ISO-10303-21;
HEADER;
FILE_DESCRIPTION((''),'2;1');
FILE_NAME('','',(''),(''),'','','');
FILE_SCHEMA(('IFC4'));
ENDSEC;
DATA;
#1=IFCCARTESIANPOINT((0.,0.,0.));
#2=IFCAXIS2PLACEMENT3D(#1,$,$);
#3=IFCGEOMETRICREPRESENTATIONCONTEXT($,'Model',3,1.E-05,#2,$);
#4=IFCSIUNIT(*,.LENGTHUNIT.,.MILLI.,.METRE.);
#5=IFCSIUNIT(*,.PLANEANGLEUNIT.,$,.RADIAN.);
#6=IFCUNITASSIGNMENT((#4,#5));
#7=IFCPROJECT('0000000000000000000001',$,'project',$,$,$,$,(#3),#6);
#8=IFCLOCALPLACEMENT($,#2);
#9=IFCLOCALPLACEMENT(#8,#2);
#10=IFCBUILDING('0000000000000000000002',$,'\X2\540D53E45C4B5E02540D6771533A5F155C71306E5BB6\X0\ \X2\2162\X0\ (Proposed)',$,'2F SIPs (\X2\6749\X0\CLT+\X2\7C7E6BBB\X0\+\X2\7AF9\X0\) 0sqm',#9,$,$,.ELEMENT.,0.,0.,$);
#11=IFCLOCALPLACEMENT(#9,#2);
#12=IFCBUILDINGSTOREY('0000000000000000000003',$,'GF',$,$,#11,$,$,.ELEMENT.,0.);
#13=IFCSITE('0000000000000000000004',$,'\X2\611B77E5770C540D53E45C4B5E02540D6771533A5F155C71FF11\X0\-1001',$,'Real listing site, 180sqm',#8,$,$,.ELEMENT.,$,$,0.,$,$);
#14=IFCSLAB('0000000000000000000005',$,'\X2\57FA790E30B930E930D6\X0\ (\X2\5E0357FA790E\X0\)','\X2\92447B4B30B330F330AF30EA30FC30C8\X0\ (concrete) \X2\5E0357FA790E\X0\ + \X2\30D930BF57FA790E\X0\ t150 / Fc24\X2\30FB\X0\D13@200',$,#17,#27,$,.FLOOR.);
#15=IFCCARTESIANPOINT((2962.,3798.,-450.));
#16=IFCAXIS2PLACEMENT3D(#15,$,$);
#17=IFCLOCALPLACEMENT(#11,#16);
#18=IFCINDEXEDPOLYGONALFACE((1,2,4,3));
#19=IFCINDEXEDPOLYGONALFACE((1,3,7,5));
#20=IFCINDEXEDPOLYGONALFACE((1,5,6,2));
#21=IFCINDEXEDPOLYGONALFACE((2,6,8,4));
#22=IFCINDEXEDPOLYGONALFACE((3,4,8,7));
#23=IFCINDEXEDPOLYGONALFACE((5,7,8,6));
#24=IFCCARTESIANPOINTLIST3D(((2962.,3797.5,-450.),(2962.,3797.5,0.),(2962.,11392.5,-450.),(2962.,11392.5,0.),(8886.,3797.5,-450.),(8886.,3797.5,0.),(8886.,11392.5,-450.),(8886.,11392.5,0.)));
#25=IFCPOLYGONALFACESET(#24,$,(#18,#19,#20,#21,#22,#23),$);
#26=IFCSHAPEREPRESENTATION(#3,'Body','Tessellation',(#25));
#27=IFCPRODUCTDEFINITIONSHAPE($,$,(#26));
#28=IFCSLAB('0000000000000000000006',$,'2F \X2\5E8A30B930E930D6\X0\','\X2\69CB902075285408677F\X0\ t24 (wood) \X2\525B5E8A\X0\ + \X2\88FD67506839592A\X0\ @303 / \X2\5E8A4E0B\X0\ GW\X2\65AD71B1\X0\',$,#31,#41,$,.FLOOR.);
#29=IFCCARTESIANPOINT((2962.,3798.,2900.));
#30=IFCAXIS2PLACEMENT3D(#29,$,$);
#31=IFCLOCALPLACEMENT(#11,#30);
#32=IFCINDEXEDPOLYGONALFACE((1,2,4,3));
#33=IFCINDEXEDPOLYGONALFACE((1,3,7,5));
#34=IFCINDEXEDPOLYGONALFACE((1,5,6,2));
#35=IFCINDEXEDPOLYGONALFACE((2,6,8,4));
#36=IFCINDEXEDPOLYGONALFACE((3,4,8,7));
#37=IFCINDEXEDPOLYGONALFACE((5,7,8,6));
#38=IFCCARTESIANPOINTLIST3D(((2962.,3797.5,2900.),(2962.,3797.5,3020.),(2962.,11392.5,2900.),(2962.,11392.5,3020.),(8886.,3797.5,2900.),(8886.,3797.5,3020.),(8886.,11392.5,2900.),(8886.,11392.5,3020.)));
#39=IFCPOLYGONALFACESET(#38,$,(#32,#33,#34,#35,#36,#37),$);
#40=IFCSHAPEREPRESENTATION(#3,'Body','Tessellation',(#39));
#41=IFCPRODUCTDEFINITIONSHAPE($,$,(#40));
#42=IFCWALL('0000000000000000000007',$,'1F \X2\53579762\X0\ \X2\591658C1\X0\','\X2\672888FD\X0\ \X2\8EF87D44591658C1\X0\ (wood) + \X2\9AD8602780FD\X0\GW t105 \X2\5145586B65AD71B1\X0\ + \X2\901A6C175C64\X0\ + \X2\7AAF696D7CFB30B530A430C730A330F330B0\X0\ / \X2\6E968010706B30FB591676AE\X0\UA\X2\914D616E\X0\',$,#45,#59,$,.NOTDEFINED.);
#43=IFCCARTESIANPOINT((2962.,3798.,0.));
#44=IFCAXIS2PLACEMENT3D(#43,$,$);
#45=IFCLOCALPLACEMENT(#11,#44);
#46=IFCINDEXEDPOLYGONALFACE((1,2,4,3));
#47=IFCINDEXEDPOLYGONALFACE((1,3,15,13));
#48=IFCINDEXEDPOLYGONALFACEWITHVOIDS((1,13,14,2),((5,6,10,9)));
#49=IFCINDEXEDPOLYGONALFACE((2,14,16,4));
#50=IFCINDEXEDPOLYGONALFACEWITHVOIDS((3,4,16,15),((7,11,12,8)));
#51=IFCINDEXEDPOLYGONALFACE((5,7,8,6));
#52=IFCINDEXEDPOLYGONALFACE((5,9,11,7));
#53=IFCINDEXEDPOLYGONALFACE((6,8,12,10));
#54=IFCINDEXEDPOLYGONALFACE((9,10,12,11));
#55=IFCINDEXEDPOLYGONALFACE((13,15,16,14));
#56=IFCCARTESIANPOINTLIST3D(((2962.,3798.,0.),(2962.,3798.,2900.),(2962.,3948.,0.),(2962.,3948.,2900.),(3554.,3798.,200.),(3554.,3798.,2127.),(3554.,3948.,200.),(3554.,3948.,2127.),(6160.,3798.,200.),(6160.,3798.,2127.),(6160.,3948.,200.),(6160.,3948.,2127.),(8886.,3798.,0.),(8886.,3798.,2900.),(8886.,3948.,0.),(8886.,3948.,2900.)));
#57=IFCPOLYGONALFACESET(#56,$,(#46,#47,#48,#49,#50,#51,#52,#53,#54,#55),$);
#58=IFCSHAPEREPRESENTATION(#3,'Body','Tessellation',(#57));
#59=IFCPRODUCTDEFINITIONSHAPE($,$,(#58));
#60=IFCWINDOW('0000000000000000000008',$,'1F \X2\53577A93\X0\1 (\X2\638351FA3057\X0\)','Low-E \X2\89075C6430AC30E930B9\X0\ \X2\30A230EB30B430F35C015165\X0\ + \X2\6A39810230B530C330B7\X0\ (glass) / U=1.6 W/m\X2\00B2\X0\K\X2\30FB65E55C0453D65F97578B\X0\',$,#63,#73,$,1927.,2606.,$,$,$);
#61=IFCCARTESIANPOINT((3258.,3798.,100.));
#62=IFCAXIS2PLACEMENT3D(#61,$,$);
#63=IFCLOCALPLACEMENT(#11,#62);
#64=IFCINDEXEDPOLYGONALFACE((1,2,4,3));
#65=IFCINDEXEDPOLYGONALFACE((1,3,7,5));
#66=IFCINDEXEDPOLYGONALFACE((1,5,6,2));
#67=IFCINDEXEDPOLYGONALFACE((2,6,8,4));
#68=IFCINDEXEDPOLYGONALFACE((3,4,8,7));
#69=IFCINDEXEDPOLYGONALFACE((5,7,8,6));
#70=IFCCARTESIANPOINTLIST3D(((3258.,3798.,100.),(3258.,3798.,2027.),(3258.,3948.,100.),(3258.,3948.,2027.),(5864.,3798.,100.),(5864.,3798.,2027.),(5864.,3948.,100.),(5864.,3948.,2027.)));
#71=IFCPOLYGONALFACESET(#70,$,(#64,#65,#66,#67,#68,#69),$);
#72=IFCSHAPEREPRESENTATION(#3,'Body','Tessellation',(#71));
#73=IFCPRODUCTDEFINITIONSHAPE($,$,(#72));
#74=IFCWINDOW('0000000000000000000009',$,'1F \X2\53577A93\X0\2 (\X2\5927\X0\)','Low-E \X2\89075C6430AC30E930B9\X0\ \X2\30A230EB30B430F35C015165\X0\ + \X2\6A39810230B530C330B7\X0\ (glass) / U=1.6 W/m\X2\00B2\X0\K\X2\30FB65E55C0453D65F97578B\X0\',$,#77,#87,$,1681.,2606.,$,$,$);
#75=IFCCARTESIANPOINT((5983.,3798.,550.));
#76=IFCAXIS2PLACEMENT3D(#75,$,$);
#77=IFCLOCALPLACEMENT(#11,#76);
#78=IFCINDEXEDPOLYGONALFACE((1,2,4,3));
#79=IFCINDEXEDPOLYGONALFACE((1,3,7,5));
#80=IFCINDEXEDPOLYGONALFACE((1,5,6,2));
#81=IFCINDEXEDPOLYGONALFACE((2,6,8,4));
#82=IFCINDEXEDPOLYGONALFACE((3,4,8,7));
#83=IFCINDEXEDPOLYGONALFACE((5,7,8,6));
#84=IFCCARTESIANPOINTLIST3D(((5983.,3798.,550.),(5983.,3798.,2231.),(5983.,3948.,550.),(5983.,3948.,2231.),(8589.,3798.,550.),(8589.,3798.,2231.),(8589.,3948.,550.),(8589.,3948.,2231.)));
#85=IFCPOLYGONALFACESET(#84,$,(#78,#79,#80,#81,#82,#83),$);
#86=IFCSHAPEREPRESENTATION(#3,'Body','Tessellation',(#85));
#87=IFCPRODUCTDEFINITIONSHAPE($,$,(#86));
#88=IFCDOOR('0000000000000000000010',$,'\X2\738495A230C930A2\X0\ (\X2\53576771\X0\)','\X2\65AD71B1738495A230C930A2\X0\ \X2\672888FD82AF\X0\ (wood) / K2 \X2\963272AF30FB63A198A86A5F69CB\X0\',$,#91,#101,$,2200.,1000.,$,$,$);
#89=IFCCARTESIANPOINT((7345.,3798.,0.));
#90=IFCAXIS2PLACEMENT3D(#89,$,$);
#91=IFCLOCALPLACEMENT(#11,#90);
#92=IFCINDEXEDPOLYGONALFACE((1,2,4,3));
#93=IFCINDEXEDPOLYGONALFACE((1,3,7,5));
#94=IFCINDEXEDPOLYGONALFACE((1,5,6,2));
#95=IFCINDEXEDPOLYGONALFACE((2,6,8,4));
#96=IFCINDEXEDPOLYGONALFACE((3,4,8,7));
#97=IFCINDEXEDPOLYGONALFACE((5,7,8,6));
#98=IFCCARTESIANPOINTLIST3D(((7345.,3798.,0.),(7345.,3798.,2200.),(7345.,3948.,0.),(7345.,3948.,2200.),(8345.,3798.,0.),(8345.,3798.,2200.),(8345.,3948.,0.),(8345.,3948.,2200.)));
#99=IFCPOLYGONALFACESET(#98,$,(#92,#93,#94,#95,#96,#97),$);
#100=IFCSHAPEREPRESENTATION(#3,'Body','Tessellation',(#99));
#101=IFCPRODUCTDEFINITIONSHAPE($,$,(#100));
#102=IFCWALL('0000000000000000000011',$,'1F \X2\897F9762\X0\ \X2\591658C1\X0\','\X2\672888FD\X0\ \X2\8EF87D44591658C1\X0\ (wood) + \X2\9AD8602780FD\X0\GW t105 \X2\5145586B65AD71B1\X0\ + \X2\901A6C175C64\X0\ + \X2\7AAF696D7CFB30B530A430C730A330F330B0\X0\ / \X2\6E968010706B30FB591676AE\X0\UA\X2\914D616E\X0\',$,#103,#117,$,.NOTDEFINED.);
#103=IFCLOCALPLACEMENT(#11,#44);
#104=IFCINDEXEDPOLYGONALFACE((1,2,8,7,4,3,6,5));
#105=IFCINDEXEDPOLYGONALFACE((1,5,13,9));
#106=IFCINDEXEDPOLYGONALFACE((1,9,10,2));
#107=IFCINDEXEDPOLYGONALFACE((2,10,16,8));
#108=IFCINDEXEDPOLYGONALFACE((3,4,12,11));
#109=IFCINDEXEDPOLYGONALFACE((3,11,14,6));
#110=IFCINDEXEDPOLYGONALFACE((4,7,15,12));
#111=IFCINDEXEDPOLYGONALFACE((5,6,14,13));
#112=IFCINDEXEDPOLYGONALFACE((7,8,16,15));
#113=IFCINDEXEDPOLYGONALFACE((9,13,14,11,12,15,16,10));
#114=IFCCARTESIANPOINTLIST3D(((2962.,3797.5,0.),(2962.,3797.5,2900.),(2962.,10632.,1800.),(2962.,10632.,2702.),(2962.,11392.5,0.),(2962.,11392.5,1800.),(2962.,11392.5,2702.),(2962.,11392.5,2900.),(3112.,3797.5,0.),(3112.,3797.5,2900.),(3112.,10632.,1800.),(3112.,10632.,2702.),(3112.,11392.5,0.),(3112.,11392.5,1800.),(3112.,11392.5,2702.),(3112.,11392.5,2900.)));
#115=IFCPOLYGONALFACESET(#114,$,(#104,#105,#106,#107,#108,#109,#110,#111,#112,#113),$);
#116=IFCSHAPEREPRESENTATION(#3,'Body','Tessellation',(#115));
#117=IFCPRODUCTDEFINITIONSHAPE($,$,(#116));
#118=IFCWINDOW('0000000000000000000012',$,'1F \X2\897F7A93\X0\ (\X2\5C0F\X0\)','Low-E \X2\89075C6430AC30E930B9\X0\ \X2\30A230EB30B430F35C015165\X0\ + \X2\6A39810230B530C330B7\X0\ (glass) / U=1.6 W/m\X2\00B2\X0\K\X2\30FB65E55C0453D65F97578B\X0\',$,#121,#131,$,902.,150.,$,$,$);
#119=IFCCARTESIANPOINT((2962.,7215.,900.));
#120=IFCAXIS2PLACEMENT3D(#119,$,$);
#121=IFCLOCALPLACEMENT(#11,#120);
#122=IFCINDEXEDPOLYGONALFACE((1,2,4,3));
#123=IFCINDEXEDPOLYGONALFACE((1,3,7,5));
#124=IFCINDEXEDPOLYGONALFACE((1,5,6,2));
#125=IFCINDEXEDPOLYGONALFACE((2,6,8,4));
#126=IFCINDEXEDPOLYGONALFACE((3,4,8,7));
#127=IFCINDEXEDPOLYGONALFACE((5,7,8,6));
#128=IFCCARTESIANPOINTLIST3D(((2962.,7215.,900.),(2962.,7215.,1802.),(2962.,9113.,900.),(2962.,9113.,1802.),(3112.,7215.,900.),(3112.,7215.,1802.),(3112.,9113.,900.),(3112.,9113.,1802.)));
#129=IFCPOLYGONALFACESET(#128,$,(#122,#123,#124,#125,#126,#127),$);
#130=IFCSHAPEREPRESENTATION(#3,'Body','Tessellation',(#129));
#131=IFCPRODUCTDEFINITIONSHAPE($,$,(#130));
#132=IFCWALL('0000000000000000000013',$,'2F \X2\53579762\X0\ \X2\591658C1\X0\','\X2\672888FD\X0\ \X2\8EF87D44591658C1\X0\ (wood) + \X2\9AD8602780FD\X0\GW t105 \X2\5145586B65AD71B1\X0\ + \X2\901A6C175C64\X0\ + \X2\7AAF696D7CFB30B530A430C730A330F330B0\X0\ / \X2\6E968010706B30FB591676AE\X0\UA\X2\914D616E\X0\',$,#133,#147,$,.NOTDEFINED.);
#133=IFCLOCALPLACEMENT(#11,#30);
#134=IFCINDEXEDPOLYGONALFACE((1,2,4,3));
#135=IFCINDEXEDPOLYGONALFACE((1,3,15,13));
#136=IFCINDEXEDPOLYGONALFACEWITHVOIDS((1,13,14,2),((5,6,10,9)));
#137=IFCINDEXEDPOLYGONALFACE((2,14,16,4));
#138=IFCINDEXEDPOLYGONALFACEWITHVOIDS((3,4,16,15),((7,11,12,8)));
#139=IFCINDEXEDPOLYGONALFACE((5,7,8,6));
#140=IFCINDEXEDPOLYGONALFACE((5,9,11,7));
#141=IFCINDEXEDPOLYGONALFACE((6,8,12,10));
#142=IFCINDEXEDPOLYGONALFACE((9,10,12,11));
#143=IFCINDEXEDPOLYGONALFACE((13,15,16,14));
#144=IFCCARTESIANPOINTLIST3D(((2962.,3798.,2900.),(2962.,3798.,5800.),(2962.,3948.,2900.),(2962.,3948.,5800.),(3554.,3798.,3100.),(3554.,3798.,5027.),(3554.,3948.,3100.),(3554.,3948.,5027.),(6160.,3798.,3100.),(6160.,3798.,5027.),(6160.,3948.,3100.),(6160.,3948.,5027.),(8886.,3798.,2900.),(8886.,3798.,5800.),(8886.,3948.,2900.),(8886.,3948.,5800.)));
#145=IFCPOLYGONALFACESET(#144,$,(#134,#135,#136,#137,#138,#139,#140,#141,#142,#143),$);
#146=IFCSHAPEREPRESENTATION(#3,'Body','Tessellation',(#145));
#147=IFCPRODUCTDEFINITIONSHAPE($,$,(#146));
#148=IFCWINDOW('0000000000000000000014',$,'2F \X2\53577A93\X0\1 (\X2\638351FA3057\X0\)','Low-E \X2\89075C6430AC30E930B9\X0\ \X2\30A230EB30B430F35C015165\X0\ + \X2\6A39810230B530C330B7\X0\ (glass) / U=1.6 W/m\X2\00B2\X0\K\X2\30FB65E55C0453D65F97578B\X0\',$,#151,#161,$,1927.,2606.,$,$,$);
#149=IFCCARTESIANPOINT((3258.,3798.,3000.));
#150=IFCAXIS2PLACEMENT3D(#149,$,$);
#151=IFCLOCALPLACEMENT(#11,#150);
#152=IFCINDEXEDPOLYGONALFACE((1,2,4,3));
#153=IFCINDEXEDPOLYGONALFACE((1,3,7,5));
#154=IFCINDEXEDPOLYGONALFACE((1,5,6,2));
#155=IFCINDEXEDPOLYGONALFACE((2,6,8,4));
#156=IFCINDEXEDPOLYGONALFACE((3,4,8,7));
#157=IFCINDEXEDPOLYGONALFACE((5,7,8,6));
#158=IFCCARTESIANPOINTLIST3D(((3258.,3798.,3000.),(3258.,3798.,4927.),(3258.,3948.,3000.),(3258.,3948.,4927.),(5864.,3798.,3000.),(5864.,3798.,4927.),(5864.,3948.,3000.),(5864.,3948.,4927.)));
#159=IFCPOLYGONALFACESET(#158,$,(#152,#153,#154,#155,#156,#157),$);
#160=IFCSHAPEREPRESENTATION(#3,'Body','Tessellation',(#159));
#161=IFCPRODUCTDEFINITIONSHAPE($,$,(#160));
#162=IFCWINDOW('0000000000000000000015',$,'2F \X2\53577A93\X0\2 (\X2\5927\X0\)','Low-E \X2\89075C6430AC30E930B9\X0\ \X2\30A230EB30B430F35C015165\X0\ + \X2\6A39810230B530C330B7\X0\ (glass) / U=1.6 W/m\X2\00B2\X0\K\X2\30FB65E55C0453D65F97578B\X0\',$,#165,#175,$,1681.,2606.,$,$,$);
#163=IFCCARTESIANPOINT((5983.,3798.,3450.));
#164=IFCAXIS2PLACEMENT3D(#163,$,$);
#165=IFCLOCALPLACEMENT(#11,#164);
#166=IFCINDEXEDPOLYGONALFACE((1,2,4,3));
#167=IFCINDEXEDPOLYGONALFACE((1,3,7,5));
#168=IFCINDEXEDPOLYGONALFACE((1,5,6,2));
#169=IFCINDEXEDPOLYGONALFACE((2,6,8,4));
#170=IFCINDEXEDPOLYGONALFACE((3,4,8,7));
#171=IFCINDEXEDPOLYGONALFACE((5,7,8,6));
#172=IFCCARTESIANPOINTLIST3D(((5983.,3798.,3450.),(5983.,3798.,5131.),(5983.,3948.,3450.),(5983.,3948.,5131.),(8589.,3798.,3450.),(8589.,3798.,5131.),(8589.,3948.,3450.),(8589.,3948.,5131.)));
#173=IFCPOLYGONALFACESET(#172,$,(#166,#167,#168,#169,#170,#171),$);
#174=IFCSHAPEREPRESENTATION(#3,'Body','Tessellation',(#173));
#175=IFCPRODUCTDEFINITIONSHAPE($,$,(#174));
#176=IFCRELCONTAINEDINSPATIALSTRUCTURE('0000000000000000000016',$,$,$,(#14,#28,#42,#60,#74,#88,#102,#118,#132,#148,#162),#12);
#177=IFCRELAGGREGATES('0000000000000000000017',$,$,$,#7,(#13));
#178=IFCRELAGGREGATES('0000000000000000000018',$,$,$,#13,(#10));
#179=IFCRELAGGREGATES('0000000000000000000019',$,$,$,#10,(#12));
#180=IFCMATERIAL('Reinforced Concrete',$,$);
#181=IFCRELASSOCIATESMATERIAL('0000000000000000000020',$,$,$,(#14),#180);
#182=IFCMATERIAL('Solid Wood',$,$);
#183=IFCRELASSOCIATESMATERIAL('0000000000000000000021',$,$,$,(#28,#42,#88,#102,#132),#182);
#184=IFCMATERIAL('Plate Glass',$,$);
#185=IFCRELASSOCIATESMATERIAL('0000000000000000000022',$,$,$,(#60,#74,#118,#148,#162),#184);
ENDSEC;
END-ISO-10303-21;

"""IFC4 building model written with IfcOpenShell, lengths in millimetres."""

from ifc_helpers import new_model, si_unit, frame, frame_2d, origin, place, context, project, spatial, rectangle, extrude, material, element, fill, save


model = new_model("IFC4")

# Units and contexts
model_context = context("Model", 3, precision=1e-05, world=origin())
ifc_project = project(units=[si_unit("LENGTHUNIT", "METRE", prefix="MILLI"), si_unit("PLANEANGLEUNIT", "RADIAN")], contexts=[model_context])

# Site, building, storey
site_placement = place(None, origin())
site = spatial("IfcSite", under=ifc_project, at=site_placement, Name="愛知県名古屋市名東区引山１-1001", ObjectType="Real listing site, 180sqm", CompositionType="ELEMENT", RefElevation=0.0)
building_placement = place(site_placement, origin())
building = spatial("IfcBuilding", under=site, at=building_placement, Name="名古屋市名東区引山の家 Ⅲ (Proposed)", ObjectType="2F SIPs (杉CLT+籾殻+竹) 0sqm", CompositionType="ELEMENT", ElevationOfRefHeight=0.0, ElevationOfTerrain=0.0)
storey_placement = place(building_placement, origin())
storey = spatial("IfcBuildingStorey", under=building, at=storey_placement, Name="GF", CompositionType="ELEMENT", Elevation=0.0)

# Slabs
ifc_material_1 = material(Name="Reinforced Concrete")
slab_1_placement = place(storey_placement, frame((2962.0, 3798.0, -450.0)))
element("IfcSlab", 1, at=slab_1_placement, inside=storey, material=ifc_material_1, Name="基礎スラブ (布基礎)", Description="鉄筋コンクリート (concrete) 布基礎 + ベタ基礎 t150 / Fc24・D13@200", PredefinedType="FLOOR", context=model_context, shape_type="SweptSolid", body=[
    extrude(rectangle(XDim=5924.0, YDim=7595.0, at=frame_2d((2962.0, 3797.0))), frame((2962.0, 3798.0, -450.0)), (0.0, 0.0, 1.0), 450.0),
])
ifc_material_2 = material(Name="Solid Wood")
slab_2_placement = place(storey_placement, frame((2962.0, 3798.0, 2900.0)))
element("IfcSlab", 2, at=slab_2_placement, inside=storey, material=ifc_material_2, Name="2F 床スラブ", Description="構造用合板 t24 (wood) 剛床 + 製材根太 @303 / 床下 GW断熱", PredefinedType="FLOOR", context=model_context, shape_type="SweptSolid", body=[
    extrude(rectangle(XDim=5924.0, YDim=7595.0, at=frame_2d((2962.0, 3797.0))), frame((2962.0, 3798.0, 2900.0)), (0.0, 0.0, 1.0), 120.0),
])

# Wall, openings, windows, door
wall_1_placement = place(storey_placement, frame((2962.0, 3798.0, 0.0)))
wall_1 = element("IfcWall", 3, at=wall_1_placement, inside=storey, material=ifc_material_2, Name="1F 南面 外壁", Description="木製 軸組外壁 (wood) + 高性能GW t105 充填断熱 + 通気層 + 窯業系サイディング / 準耐火・外皮UA配慮", PredefinedType="NOTDEFINED", context=model_context, shape_type="SweptSolid", body=[
    extrude(rectangle(XDim=5924.0, YDim=150.0, at=frame_2d((2962.0, 75.0))), frame((2962.0, 3798.0, 0.0)), (0.0, 0.0, 1.0), 2900.0),
])
opening_1_placement = place(storey_placement, frame((3258.0, 3798.0, 100.0)))
opening_1 = element("IfcOpeningElement", 4, at=opening_1_placement, cuts=wall_1, PredefinedType="NOTDEFINED", context=model_context, shape_type="SweptSolid", body=[
    extrude(rectangle(XDim=2606.0, YDim=150.0, at=frame_2d((1303.0, 75.0))), frame((3258.0, 3798.0, 100.0)), (0.0, 0.0, 1.0), 1927.0),
])
opening_2_placement = place(storey_placement, frame((5983.0, 3798.0, 550.0)))
opening_2 = element("IfcOpeningElement", 5, at=opening_2_placement, cuts=wall_1, PredefinedType="NOTDEFINED", context=model_context, shape_type="SweptSolid", body=[
    extrude(rectangle(XDim=2606.0, YDim=150.0, at=frame_2d((1303.0, 75.0))), frame((5983.0, 3798.0, 550.0)), (0.0, 0.0, 1.0), 1681.0),
])
opening_3_placement = place(storey_placement, frame((7345.0, 3798.0, 0.0)))
opening_3 = element("IfcOpeningElement", 6, at=opening_3_placement, cuts=wall_1, PredefinedType="NOTDEFINED", context=model_context, shape_type="SweptSolid", body=[
    extrude(rectangle(XDim=1000.0, YDim=150.0, at=frame_2d((500.0, 75.0))), frame((7345.0, 3798.0, 0.0)), (0.0, 0.0, 1.0), 2200.0),
])
ifc_material_3 = material(Name="Plate Glass")
window_1_placement = place(storey_placement, frame((3258.0, 3798.0, 100.0)))
window_1 = element("IfcWindow", 7, at=window_1_placement, inside=storey, material=ifc_material_3, Name="1F 南窓1 (掃出し)", Description="Low-E 複層ガラス アルゴン封入 + 樹脂サッシ (glass) / U=1.6 W/m²K・日射取得型", OverallHeight=1927.0, OverallWidth=2606.0, context=model_context, shape_type="SweptSolid", body=[
    extrude(rectangle(XDim=2606.0, YDim=150.0, at=frame_2d((1303.0, 75.0))), frame((3258.0, 3798.0, 100.0)), (0.0, 0.0, 1.0), 1927.0),
])
fill(opening_1, window_1)
window_2_placement = place(storey_placement, frame((5983.0, 3798.0, 550.0)))
window_2 = element("IfcWindow", 8, at=window_2_placement, inside=storey, material=ifc_material_3, Name="1F 南窓2 (大)", Description="Low-E 複層ガラス アルゴン封入 + 樹脂サッシ (glass) / U=1.6 W/m²K・日射取得型", OverallHeight=1681.0, OverallWidth=2606.0, context=model_context, shape_type="SweptSolid", body=[
    extrude(rectangle(XDim=2606.0, YDim=150.0, at=frame_2d((1303.0, 75.0))), frame((5983.0, 3798.0, 550.0)), (0.0, 0.0, 1.0), 1681.0),
])
fill(opening_2, window_2)
door_placement = place(storey_placement, frame((7345.0, 3798.0, 0.0)))
door = element("IfcDoor", 9, at=door_placement, inside=storey, material=ifc_material_2, Name="玄関ドア (南東)", Description="断熱玄関ドア 木製芯 (wood) / K2 防犯・採風機構", OverallHeight=2200.0, OverallWidth=1000.0, context=model_context, shape_type="SweptSolid", body=[
    extrude(rectangle(XDim=1000.0, YDim=150.0, at=frame_2d((500.0, 75.0))), frame((7345.0, 3798.0, 0.0)), (0.0, 0.0, 1.0), 2200.0),
])
fill(opening_3, door)

# Wall, opening, window
wall_2_placement = place(storey_placement, frame((2962.0, 3798.0, 0.0)))
wall_2 = element("IfcWall", 10, at=wall_2_placement, inside=storey, material=ifc_material_2, Name="1F 西面 外壁", Description="木製 軸組外壁 (wood) + 高性能GW t105 充填断熱 + 通気層 + 窯業系サイディング / 準耐火・外皮UA配慮", PredefinedType="NOTDEFINED", context=model_context, shape_type="SweptSolid", body=[
    extrude(rectangle(XDim=150.0, YDim=7595.0, at=frame_2d((75.0, 3797.0))), frame((2962.0, 3798.0, 0.0)), (0.0, 0.0, 1.0), 2900.0),
])
opening_4_placement = place(storey_placement, frame((2962.0, 7215.0, 900.0)))
opening_4 = element("IfcOpeningElement", 11, at=opening_4_placement, cuts=wall_2, PredefinedType="NOTDEFINED", context=model_context, shape_type="SweptSolid", body=[
    extrude(rectangle(XDim=150.0, YDim=1898.0, at=frame_2d((75.0, 949.0))), frame((2962.0, 7215.0, 900.0)), (0.0, 0.0, 1.0), 902.0),
])
window_3_placement = place(storey_placement, frame((2962.0, 7215.0, 900.0)))
window_3 = element("IfcWindow", 12, at=window_3_placement, inside=storey, material=ifc_material_3, Name="1F 西窓 (小)", Description="Low-E 複層ガラス アルゴン封入 + 樹脂サッシ (glass) / U=1.6 W/m²K・日射取得型", OverallHeight=902.0, OverallWidth=150.0, context=model_context, shape_type="SweptSolid", body=[
    extrude(rectangle(XDim=150.0, YDim=1898.0, at=frame_2d((75.0, 949.0))), frame((2962.0, 7215.0, 900.0)), (0.0, 0.0, 1.0), 902.0),
])
fill(opening_4, window_3)

# Wall, openings, windows
wall_3_placement = place(storey_placement, frame((2962.0, 3798.0, 2900.0)))
wall_3 = element("IfcWall", 13, at=wall_3_placement, inside=storey, material=ifc_material_2, Name="2F 南面 外壁", Description="木製 軸組外壁 (wood) + 高性能GW t105 充填断熱 + 通気層 + 窯業系サイディング / 準耐火・外皮UA配慮", PredefinedType="NOTDEFINED", context=model_context, shape_type="SweptSolid", body=[
    extrude(rectangle(XDim=5924.0, YDim=150.0, at=frame_2d((2962.0, 75.0))), frame((2962.0, 3798.0, 2900.0)), (0.0, 0.0, 1.0), 2900.0),
])
opening_5_placement = place(storey_placement, frame((3258.0, 3798.0, 3000.0)))
opening_5 = element("IfcOpeningElement", 14, at=opening_5_placement, cuts=wall_3, PredefinedType="NOTDEFINED", context=model_context, shape_type="SweptSolid", body=[
    extrude(rectangle(XDim=2606.0, YDim=150.0, at=frame_2d((1303.0, 75.0))), frame((3258.0, 3798.0, 3000.0)), (0.0, 0.0, 1.0), 1927.0),
])
opening_6_placement = place(storey_placement, frame((5983.0, 3798.0, 3450.0)))
opening_6 = element("IfcOpeningElement", 15, at=opening_6_placement, cuts=wall_3, PredefinedType="NOTDEFINED", context=model_context, shape_type="SweptSolid", body=[
    extrude(rectangle(XDim=2606.0, YDim=150.0, at=frame_2d((1303.0, 75.0))), frame((5983.0, 3798.0, 3450.0)), (0.0, 0.0, 1.0), 1681.0),
])
window_4_placement = place(storey_placement, frame((3258.0, 3798.0, 3000.0)))
window_4 = element("IfcWindow", 16, at=window_4_placement, inside=storey, material=ifc_material_3, Name="2F 南窓1 (掃出し)", Description="Low-E 複層ガラス アルゴン封入 + 樹脂サッシ (glass) / U=1.6 W/m²K・日射取得型", OverallHeight=1927.0, OverallWidth=2606.0, context=model_context, shape_type="SweptSolid", body=[
    extrude(rectangle(XDim=2606.0, YDim=150.0, at=frame_2d((1303.0, 75.0))), frame((3258.0, 3798.0, 3000.0)), (0.0, 0.0, 1.0), 1927.0),
])
fill(opening_5, window_4)
window_5_placement = place(storey_placement, frame((5983.0, 3798.0, 3450.0)))
window_5 = element("IfcWindow", 17, at=window_5_placement, inside=storey, material=ifc_material_3, Name="2F 南窓2 (大)", Description="Low-E 複層ガラス アルゴン封入 + 樹脂サッシ (glass) / U=1.6 W/m²K・日射取得型", OverallHeight=1681.0, OverallWidth=2606.0, context=model_context, shape_type="SweptSolid", body=[
    extrude(rectangle(XDim=2606.0, YDim=150.0, at=frame_2d((1303.0, 75.0))), frame((5983.0, 3798.0, 3450.0)), (0.0, 0.0, 1.0), 1681.0),
])
fill(opening_6, window_5)

save(model, "model.ifc")
